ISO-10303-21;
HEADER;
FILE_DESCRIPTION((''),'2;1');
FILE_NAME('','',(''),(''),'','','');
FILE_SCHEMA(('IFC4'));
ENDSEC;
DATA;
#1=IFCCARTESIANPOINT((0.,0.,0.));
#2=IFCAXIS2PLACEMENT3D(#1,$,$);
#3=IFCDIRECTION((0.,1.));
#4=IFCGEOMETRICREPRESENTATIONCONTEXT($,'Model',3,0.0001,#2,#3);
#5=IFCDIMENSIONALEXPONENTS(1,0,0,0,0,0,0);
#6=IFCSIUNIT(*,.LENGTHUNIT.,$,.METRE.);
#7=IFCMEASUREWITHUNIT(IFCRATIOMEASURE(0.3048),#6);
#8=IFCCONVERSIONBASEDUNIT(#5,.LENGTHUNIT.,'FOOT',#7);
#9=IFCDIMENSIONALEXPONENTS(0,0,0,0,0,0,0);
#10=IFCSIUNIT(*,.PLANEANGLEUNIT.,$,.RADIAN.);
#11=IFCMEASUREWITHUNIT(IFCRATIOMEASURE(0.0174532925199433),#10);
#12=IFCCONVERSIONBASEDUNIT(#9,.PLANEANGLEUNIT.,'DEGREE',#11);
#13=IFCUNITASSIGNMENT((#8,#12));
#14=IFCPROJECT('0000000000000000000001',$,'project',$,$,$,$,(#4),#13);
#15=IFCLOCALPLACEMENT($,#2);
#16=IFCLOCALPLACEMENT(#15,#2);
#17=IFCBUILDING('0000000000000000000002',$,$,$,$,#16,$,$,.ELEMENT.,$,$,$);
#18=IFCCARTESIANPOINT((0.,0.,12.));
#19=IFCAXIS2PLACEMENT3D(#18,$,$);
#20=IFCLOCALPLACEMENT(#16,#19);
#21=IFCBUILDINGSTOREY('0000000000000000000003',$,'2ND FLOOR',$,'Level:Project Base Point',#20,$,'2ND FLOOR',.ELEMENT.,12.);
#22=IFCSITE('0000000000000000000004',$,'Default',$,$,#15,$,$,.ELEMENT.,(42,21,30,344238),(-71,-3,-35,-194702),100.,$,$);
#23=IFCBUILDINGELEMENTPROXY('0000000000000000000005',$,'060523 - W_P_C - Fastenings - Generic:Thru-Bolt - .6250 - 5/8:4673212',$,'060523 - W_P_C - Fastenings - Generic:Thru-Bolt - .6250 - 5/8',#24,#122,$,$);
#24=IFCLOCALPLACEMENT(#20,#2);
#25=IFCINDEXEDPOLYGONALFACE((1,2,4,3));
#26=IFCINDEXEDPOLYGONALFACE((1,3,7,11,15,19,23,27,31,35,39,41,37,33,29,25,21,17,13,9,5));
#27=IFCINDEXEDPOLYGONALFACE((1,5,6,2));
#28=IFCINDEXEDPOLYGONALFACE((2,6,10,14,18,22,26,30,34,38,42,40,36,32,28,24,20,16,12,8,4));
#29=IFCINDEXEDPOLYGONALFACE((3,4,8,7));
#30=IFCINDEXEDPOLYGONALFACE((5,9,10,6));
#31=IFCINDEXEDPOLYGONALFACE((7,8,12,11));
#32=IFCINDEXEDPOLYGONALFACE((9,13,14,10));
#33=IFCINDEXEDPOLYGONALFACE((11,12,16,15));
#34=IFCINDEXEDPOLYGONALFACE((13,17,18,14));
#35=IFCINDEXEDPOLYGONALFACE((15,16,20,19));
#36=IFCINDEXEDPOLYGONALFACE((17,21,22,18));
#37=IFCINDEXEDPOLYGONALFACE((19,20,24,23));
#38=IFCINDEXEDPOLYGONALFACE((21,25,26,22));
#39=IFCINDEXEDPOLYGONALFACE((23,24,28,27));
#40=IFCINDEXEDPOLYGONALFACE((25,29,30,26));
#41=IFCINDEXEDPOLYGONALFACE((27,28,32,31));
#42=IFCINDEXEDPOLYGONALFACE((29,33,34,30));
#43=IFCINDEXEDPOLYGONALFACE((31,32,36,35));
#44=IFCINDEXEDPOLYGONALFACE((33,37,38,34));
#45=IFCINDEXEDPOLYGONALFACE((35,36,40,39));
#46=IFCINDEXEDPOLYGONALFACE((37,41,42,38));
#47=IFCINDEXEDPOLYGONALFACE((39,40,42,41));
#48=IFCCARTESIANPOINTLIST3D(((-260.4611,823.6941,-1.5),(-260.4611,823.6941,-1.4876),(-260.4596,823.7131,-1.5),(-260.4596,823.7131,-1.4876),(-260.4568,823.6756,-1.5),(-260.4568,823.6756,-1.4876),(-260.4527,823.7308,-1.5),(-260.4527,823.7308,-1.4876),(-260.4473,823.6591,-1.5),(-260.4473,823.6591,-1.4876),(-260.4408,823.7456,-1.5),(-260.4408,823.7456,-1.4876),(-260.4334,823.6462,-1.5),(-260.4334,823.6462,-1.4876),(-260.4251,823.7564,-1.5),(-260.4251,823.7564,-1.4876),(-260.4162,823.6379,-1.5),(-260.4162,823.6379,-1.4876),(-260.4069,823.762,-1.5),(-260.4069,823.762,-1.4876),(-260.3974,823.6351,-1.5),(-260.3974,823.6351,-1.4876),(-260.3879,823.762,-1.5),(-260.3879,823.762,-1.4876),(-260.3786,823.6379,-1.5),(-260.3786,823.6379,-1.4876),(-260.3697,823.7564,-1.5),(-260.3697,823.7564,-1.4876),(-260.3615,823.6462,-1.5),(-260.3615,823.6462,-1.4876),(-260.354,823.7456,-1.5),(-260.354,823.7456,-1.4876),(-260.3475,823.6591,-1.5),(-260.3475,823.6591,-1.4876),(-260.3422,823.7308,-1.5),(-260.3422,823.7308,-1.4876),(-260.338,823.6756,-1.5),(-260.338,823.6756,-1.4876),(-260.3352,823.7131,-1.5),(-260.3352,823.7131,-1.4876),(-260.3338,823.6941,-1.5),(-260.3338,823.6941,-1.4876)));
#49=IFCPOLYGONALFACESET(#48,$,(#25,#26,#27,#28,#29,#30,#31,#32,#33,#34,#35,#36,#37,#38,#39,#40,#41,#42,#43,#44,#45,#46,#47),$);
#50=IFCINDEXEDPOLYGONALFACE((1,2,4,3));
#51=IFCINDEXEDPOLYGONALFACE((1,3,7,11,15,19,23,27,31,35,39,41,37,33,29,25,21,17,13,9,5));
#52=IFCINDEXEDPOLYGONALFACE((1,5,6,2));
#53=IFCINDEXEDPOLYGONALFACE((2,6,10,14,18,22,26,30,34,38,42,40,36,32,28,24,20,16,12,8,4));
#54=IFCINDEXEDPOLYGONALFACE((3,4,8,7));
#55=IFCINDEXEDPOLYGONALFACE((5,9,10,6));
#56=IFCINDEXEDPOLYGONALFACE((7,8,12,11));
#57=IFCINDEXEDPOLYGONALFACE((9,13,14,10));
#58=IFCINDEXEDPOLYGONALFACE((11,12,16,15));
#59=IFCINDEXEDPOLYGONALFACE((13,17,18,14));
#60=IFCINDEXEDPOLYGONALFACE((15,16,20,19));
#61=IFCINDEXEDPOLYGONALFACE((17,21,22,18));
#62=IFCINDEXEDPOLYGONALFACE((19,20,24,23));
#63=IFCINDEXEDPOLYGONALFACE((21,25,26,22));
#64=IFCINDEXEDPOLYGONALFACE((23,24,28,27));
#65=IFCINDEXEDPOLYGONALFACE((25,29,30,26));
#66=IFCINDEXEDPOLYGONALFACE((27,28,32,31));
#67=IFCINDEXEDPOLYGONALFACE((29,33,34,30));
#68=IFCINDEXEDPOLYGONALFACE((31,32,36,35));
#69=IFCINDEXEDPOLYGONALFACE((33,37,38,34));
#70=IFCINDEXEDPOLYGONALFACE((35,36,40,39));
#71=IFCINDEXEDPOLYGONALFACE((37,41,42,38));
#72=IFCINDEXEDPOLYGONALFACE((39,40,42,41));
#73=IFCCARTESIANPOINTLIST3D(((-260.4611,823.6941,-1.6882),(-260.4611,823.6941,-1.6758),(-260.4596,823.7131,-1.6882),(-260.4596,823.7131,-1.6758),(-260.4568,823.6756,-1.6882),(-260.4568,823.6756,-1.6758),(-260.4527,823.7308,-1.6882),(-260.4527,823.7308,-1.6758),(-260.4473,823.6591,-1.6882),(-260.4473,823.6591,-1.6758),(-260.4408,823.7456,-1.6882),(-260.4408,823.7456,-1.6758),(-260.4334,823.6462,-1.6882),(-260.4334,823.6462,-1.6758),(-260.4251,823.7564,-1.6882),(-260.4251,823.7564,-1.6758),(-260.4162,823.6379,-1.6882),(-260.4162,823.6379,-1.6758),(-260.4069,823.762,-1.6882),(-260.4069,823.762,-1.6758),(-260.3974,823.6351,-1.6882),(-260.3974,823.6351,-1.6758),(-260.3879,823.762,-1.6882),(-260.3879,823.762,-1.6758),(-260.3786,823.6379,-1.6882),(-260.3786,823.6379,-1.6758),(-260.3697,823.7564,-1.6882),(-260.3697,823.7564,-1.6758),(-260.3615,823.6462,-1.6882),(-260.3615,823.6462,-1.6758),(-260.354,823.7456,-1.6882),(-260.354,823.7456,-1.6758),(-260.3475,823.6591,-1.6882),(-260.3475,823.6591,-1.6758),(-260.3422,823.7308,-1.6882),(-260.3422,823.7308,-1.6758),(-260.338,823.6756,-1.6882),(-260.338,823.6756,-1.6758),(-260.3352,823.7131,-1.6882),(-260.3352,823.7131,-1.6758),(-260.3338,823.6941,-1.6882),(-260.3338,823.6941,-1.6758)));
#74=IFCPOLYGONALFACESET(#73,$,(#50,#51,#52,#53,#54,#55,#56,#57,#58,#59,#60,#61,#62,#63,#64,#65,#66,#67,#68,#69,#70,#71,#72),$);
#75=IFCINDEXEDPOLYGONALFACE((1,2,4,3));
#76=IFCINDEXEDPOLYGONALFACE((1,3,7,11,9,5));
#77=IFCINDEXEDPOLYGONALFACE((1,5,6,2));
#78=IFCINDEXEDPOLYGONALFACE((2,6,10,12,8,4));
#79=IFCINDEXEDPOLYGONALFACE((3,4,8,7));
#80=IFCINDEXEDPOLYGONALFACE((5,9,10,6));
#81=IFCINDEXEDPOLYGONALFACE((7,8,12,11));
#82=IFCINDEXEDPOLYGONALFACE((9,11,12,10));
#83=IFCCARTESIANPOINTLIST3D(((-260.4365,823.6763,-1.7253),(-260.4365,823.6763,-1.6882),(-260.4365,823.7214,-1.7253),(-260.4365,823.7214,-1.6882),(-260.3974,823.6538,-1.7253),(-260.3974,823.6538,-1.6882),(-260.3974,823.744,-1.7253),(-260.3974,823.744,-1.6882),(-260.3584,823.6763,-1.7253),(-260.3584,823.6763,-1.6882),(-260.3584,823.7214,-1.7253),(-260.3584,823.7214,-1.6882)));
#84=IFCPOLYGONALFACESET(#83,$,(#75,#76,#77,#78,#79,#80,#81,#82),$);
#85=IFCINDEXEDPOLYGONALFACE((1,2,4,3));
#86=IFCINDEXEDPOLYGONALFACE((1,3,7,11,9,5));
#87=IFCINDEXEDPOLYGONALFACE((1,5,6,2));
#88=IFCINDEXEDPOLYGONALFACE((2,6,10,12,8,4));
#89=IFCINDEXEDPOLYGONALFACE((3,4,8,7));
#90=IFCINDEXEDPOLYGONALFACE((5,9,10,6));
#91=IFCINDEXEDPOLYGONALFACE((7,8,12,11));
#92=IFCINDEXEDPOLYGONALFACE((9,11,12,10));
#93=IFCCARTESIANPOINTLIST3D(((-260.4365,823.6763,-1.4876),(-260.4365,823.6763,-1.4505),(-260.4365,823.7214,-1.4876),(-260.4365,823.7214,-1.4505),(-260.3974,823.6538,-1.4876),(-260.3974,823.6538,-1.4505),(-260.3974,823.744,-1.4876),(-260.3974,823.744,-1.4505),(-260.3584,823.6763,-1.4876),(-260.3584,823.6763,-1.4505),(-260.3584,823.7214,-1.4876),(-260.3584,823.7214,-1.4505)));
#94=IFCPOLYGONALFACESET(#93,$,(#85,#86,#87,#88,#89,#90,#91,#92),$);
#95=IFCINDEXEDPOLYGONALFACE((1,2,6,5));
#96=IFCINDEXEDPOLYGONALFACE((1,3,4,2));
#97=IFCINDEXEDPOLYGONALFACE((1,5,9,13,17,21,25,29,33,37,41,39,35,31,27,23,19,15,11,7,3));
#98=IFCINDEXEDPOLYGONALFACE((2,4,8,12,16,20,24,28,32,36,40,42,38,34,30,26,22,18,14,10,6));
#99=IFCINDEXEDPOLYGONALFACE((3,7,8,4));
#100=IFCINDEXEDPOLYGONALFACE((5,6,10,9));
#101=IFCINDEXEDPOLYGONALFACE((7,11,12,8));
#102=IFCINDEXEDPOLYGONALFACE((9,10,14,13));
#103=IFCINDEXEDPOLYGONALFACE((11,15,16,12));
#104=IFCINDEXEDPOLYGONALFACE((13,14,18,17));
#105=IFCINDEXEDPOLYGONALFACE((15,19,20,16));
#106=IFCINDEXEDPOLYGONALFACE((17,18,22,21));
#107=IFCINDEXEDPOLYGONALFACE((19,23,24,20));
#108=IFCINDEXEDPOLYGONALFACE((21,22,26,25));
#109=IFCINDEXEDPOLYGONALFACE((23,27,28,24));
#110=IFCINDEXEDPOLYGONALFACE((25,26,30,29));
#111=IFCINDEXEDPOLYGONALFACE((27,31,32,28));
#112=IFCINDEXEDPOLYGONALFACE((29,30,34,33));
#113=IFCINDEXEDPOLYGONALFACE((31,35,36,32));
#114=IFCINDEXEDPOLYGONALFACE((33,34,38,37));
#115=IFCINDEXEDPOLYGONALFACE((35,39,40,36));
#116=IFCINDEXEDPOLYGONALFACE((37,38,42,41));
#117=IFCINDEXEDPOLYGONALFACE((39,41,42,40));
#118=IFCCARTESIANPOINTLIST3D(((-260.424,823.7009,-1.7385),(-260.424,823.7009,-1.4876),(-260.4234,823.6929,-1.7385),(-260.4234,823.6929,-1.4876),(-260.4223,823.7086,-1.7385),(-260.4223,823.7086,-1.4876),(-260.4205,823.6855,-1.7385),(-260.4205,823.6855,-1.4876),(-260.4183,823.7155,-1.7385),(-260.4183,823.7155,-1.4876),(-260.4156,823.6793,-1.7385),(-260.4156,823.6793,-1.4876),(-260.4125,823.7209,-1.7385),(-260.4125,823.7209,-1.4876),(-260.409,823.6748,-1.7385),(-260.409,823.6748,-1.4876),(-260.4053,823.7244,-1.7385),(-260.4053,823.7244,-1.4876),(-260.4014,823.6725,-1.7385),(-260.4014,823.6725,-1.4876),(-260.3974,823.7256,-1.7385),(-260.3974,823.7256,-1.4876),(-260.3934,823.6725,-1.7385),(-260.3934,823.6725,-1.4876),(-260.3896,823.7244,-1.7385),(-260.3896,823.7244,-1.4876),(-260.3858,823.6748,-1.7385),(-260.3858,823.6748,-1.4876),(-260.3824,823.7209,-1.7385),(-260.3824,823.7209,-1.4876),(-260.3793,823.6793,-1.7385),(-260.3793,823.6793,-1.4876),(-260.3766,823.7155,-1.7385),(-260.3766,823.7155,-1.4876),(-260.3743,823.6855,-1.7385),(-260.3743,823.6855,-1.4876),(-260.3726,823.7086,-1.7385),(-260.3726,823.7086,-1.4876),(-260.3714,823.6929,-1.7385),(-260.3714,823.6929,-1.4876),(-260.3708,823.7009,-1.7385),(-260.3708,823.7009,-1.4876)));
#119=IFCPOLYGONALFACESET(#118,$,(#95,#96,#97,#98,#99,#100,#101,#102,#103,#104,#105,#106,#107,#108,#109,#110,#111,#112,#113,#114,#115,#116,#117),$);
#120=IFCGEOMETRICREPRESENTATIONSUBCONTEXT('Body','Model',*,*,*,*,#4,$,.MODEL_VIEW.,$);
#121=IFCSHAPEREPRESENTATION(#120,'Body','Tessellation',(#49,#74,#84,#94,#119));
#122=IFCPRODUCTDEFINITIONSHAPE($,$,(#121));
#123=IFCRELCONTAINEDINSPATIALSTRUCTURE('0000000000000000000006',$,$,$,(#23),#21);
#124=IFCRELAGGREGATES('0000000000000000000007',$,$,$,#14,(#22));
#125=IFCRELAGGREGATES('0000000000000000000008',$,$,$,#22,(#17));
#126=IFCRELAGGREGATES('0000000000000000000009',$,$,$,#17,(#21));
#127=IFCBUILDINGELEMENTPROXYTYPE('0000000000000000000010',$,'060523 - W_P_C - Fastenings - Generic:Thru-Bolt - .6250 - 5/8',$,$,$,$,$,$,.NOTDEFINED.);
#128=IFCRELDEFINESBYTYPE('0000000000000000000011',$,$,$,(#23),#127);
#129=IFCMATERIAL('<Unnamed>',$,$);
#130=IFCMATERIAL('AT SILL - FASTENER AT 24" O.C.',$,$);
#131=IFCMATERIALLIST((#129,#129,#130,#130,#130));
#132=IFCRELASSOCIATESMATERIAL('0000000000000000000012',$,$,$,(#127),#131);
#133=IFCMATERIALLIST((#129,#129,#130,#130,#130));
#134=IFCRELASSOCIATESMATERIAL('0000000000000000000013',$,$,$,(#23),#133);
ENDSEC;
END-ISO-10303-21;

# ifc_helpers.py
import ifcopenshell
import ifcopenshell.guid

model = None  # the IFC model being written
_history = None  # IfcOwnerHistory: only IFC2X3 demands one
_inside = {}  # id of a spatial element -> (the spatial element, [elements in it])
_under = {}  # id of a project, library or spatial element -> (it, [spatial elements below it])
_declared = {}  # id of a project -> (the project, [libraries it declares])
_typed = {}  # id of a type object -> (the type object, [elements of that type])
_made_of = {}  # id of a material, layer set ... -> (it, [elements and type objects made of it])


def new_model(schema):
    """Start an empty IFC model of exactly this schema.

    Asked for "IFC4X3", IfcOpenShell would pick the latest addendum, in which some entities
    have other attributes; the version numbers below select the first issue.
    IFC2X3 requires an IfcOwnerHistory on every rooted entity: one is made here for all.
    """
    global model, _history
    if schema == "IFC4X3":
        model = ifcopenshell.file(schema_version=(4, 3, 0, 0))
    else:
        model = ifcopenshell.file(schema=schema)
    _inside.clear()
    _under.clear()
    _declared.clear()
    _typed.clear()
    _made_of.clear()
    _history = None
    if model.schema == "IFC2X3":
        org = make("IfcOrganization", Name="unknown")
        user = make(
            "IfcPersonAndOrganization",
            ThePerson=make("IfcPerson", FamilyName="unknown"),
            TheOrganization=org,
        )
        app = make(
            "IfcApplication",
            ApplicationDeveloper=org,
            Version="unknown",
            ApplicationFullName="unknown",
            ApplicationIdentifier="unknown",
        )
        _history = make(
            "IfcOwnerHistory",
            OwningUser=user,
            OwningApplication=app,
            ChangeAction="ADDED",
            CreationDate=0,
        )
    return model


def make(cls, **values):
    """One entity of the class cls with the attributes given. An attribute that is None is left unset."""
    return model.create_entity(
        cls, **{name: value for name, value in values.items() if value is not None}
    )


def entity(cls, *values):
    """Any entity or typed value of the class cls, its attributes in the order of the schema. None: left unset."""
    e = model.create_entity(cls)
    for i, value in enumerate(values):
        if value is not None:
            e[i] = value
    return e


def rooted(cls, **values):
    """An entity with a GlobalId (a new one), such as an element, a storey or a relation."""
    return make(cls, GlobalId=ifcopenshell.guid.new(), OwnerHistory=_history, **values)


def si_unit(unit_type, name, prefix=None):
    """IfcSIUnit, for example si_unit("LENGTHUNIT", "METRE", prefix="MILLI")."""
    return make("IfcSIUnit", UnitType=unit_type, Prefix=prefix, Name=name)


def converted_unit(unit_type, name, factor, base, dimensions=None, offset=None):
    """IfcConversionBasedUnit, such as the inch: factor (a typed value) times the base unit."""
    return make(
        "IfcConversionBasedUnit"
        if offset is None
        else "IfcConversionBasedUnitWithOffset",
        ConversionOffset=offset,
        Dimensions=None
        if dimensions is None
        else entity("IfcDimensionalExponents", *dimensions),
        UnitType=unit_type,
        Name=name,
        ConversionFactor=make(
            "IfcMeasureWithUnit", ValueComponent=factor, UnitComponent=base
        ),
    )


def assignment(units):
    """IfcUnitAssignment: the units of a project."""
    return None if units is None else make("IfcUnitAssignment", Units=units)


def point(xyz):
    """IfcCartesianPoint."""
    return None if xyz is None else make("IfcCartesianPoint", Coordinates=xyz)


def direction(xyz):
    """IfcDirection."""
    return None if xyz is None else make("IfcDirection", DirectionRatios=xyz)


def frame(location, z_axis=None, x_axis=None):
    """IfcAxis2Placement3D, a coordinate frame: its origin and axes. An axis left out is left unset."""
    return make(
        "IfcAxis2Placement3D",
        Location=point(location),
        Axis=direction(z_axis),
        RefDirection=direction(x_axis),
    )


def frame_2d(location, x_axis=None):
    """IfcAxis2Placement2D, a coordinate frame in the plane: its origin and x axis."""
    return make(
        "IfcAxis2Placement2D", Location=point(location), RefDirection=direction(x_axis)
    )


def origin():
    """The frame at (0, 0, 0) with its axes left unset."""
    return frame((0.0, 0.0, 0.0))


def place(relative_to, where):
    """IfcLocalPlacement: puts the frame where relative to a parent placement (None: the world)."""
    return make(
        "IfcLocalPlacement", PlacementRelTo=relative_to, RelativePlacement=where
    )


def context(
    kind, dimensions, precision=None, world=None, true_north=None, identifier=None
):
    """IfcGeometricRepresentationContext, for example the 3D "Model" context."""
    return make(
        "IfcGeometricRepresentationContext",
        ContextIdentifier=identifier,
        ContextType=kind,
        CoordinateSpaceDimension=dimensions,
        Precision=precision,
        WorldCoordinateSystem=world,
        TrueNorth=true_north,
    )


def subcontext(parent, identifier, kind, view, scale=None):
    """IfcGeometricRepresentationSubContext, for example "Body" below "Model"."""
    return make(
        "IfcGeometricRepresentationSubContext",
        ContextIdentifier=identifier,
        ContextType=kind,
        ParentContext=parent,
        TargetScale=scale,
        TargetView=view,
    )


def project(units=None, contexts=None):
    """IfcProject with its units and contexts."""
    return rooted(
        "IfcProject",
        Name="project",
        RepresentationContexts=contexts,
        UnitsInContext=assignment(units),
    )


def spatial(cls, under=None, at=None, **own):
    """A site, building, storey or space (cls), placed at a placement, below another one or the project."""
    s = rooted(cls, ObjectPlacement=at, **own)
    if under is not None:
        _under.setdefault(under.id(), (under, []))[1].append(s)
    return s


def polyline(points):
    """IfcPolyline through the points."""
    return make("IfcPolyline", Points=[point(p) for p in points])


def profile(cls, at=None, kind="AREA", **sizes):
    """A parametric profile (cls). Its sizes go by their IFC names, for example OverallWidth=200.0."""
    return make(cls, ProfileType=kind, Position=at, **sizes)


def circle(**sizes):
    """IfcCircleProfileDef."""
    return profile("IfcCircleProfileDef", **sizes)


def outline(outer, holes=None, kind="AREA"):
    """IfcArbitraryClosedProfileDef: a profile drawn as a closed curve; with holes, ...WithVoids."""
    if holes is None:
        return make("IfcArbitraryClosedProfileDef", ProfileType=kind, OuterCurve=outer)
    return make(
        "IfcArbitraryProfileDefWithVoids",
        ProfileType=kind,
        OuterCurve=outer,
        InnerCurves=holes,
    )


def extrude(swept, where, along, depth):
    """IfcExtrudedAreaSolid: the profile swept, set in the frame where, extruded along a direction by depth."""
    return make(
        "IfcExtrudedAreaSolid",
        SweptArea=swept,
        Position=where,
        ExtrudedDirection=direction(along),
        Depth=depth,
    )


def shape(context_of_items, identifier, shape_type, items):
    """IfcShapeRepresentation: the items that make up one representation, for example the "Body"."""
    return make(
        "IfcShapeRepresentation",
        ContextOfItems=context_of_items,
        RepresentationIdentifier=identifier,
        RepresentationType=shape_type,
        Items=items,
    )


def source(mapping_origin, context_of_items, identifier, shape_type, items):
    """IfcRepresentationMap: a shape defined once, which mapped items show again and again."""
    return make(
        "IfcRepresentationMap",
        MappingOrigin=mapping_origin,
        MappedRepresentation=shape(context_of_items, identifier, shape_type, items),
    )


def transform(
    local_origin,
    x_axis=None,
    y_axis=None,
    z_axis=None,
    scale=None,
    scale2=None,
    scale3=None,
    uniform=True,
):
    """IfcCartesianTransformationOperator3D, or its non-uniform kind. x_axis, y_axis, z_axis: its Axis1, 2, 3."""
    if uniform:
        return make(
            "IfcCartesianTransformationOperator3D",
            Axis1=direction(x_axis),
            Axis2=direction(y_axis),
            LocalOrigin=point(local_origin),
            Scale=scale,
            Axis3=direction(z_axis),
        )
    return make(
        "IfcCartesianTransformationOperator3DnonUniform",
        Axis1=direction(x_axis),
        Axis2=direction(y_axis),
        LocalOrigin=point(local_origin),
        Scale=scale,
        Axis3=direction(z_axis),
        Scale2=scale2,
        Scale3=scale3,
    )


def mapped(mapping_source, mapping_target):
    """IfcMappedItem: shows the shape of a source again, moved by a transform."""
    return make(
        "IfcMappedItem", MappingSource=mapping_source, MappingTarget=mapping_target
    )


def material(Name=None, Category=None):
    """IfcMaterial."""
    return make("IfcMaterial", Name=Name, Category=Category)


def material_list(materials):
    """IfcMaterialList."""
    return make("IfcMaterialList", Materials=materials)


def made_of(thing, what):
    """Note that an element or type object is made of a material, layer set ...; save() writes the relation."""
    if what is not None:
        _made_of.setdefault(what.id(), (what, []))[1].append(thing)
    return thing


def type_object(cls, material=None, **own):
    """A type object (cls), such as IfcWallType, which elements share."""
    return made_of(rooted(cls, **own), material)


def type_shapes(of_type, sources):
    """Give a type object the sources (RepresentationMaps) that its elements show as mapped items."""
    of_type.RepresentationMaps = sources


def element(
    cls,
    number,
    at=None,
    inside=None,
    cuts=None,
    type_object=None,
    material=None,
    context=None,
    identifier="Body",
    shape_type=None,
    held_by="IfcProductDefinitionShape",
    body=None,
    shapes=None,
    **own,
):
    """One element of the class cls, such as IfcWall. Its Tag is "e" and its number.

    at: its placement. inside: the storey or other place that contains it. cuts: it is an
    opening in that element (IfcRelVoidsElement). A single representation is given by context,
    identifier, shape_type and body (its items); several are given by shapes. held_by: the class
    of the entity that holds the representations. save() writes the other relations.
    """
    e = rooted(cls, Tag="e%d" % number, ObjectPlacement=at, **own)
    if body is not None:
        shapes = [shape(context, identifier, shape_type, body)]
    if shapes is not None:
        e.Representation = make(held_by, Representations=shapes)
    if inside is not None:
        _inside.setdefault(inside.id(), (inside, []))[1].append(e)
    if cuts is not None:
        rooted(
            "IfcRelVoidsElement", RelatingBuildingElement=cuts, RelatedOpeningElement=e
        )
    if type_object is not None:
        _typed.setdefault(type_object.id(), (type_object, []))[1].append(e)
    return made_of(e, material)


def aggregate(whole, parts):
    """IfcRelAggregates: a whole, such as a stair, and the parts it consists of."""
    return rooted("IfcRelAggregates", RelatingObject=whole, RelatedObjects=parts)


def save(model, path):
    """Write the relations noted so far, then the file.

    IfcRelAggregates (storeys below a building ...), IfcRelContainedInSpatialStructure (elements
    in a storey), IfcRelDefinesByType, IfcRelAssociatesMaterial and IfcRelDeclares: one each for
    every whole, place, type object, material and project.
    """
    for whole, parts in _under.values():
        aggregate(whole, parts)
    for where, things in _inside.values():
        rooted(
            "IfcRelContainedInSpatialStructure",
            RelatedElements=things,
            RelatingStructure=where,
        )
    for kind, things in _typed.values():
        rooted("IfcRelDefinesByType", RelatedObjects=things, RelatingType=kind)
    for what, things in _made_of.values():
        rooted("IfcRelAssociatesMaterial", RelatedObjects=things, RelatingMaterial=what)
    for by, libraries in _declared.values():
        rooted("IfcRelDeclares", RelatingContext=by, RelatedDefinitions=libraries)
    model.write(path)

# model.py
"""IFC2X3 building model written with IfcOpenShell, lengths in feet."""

from ifc_helpers import new_model, entity, si_unit, converted_unit, direction, frame, frame_2d, origin, place, context, subcontext, project, spatial, polyline, circle, outline, extrude, source, transform, mapped, material, material_list, type_object, type_shapes, element, save


model = new_model("IFC2X3")

# Units and contexts
model_context = context("Model", 3, precision=0.0001, world=origin(), true_north=direction((0.0, 1.0)))
body_context = subcontext(model_context, "Body", "Model", "MODEL_VIEW")
ifc_project = project(units=[converted_unit("LENGTHUNIT", "FOOT", entity("IfcRatioMeasure", 0.3048), si_unit("LENGTHUNIT", "METRE"), dimensions=[1, 0, 0, 0, 0, 0, 0]), converted_unit("PLANEANGLEUNIT", "DEGREE", entity("IfcRatioMeasure", 0.0174532925199433), si_unit("PLANEANGLEUNIT", "RADIAN"), dimensions=[0, 0, 0, 0, 0, 0, 0])], contexts=[model_context])

# Site, building, storey
site_placement = place(None, origin())
site = spatial("IfcSite", under=ifc_project, at=site_placement, Name="Default", CompositionType="ELEMENT", RefLatitude=(42, 21, 30, 344238), RefLongitude=(-71, -3, -35, -194702), RefElevation=100.0)
building_placement = place(site_placement, origin())
building = spatial("IfcBuilding", under=site, at=building_placement, CompositionType="ELEMENT")
storey_placement = place(building_placement, frame((0.0, 0.0, 12.0)))
storey = spatial("IfcBuildingStorey", under=building, at=storey_placement, Name="2ND FLOOR", ObjectType="Level:Project Base Point", LongName="2ND FLOOR", CompositionType="ELEMENT", Elevation=12.0)

# Building element proxy
ifc_material_1 = material(Name="<Unnamed>")
ifc_material_2 = material(Name="AT SILL - FASTENER AT 24\" O.C.")
ifc_material_list_1 = material_list([ifc_material_1, ifc_material_1, ifc_material_2, ifc_material_2, ifc_material_2])
ifc_material_list_2 = material_list([ifc_material_1, ifc_material_1, ifc_material_2, ifc_material_2, ifc_material_2])
building_element_proxy_type_1 = type_object("IfcBuildingElementProxyType", Name="060523 - W_P_C - Fastenings - Generic:Thru-Bolt - .6250 - 5/8", PredefinedType="NOTDEFINED", material=ifc_material_list_2)
shared_shape_1 = source(origin(), body_context, "Body", "SweptSolid", [
    extrude(circle(Radius=0.0638, at=frame_2d((0.0, 0.0), x_axis=(1.0, 0.0))), frame((0.0, 0.0, 0.0), z_axis=(0.0, 0.0, 1.0), x_axis=(0.0, -1.0, 0.0)), (0.0, 0.0, 1.0), 0.0124),
    extrude(circle(Radius=0.0638, at=frame_2d((0.0, 0.0), x_axis=(1.0, 0.0))), frame((0.0, 0.0, -0.1882), z_axis=(0.0, 0.0, 1.0), x_axis=(0.0, -1.0, 0.0)), (0.0, 0.0, 1.0), 0.0124),
    extrude(outline(polyline([(-0.0226, -0.0391), (0.0226, -0.0391), (0.0451, 0.0), (0.0226, 0.0391), (-0.0226, 0.0391), (-0.0451, 0.0), (-0.0226, -0.0391)])), frame((0.0, 0.0, -0.2253), z_axis=(0.0, 0.0, 1.0), x_axis=(0.866025, -0.5, 0.0)), (0.0, 0.0, 1.0), 0.0371),
    extrude(outline(polyline([(-0.0226, -0.0391), (0.0226, -0.0391), (0.0451, 0.0), (0.0226, 0.0391), (-0.0226, 0.0391), (-0.0451, 0.0), (-0.0226, -0.0391)])), frame((0.0, 0.0, 0.0124), z_axis=(0.0, 0.0, 1.0), x_axis=(0.0, -1.0, 0.0)), (0.0, 0.0, 1.0), 0.0371),
    extrude(circle(Radius=0.0267, at=frame_2d((0.0, 0.0), x_axis=(1.0, 0.0))), frame((0.0, 0.0, -0.2385), z_axis=(0.0, 0.0, 1.0), x_axis=(0.0, 1.0, 0.0)), (0.0, 0.0, 1.0), 0.2509),
])
type_shapes(building_element_proxy_type_1, [shared_shape_1])
proxy_1_placement = place(storey_placement, frame((-260.3974, 823.6989, -1.5)))
element("IfcBuildingElementProxy", 1, at=proxy_1_placement, inside=storey, type_object=building_element_proxy_type_1, material=ifc_material_list_1, Name="060523 - W_P_C - Fastenings - Generic:Thru-Bolt - .6250 - 5/8:4673212", ObjectType="060523 - W_P_C - Fastenings - Generic:Thru-Bolt - .6250 - 5/8", context=body_context, shape_type="MappedRepresentation", body=[
    mapped(shared_shape_1, transform((0.0, 0.0, 0.0), scale=1.0)),
])

save(model, "model.ifc")
